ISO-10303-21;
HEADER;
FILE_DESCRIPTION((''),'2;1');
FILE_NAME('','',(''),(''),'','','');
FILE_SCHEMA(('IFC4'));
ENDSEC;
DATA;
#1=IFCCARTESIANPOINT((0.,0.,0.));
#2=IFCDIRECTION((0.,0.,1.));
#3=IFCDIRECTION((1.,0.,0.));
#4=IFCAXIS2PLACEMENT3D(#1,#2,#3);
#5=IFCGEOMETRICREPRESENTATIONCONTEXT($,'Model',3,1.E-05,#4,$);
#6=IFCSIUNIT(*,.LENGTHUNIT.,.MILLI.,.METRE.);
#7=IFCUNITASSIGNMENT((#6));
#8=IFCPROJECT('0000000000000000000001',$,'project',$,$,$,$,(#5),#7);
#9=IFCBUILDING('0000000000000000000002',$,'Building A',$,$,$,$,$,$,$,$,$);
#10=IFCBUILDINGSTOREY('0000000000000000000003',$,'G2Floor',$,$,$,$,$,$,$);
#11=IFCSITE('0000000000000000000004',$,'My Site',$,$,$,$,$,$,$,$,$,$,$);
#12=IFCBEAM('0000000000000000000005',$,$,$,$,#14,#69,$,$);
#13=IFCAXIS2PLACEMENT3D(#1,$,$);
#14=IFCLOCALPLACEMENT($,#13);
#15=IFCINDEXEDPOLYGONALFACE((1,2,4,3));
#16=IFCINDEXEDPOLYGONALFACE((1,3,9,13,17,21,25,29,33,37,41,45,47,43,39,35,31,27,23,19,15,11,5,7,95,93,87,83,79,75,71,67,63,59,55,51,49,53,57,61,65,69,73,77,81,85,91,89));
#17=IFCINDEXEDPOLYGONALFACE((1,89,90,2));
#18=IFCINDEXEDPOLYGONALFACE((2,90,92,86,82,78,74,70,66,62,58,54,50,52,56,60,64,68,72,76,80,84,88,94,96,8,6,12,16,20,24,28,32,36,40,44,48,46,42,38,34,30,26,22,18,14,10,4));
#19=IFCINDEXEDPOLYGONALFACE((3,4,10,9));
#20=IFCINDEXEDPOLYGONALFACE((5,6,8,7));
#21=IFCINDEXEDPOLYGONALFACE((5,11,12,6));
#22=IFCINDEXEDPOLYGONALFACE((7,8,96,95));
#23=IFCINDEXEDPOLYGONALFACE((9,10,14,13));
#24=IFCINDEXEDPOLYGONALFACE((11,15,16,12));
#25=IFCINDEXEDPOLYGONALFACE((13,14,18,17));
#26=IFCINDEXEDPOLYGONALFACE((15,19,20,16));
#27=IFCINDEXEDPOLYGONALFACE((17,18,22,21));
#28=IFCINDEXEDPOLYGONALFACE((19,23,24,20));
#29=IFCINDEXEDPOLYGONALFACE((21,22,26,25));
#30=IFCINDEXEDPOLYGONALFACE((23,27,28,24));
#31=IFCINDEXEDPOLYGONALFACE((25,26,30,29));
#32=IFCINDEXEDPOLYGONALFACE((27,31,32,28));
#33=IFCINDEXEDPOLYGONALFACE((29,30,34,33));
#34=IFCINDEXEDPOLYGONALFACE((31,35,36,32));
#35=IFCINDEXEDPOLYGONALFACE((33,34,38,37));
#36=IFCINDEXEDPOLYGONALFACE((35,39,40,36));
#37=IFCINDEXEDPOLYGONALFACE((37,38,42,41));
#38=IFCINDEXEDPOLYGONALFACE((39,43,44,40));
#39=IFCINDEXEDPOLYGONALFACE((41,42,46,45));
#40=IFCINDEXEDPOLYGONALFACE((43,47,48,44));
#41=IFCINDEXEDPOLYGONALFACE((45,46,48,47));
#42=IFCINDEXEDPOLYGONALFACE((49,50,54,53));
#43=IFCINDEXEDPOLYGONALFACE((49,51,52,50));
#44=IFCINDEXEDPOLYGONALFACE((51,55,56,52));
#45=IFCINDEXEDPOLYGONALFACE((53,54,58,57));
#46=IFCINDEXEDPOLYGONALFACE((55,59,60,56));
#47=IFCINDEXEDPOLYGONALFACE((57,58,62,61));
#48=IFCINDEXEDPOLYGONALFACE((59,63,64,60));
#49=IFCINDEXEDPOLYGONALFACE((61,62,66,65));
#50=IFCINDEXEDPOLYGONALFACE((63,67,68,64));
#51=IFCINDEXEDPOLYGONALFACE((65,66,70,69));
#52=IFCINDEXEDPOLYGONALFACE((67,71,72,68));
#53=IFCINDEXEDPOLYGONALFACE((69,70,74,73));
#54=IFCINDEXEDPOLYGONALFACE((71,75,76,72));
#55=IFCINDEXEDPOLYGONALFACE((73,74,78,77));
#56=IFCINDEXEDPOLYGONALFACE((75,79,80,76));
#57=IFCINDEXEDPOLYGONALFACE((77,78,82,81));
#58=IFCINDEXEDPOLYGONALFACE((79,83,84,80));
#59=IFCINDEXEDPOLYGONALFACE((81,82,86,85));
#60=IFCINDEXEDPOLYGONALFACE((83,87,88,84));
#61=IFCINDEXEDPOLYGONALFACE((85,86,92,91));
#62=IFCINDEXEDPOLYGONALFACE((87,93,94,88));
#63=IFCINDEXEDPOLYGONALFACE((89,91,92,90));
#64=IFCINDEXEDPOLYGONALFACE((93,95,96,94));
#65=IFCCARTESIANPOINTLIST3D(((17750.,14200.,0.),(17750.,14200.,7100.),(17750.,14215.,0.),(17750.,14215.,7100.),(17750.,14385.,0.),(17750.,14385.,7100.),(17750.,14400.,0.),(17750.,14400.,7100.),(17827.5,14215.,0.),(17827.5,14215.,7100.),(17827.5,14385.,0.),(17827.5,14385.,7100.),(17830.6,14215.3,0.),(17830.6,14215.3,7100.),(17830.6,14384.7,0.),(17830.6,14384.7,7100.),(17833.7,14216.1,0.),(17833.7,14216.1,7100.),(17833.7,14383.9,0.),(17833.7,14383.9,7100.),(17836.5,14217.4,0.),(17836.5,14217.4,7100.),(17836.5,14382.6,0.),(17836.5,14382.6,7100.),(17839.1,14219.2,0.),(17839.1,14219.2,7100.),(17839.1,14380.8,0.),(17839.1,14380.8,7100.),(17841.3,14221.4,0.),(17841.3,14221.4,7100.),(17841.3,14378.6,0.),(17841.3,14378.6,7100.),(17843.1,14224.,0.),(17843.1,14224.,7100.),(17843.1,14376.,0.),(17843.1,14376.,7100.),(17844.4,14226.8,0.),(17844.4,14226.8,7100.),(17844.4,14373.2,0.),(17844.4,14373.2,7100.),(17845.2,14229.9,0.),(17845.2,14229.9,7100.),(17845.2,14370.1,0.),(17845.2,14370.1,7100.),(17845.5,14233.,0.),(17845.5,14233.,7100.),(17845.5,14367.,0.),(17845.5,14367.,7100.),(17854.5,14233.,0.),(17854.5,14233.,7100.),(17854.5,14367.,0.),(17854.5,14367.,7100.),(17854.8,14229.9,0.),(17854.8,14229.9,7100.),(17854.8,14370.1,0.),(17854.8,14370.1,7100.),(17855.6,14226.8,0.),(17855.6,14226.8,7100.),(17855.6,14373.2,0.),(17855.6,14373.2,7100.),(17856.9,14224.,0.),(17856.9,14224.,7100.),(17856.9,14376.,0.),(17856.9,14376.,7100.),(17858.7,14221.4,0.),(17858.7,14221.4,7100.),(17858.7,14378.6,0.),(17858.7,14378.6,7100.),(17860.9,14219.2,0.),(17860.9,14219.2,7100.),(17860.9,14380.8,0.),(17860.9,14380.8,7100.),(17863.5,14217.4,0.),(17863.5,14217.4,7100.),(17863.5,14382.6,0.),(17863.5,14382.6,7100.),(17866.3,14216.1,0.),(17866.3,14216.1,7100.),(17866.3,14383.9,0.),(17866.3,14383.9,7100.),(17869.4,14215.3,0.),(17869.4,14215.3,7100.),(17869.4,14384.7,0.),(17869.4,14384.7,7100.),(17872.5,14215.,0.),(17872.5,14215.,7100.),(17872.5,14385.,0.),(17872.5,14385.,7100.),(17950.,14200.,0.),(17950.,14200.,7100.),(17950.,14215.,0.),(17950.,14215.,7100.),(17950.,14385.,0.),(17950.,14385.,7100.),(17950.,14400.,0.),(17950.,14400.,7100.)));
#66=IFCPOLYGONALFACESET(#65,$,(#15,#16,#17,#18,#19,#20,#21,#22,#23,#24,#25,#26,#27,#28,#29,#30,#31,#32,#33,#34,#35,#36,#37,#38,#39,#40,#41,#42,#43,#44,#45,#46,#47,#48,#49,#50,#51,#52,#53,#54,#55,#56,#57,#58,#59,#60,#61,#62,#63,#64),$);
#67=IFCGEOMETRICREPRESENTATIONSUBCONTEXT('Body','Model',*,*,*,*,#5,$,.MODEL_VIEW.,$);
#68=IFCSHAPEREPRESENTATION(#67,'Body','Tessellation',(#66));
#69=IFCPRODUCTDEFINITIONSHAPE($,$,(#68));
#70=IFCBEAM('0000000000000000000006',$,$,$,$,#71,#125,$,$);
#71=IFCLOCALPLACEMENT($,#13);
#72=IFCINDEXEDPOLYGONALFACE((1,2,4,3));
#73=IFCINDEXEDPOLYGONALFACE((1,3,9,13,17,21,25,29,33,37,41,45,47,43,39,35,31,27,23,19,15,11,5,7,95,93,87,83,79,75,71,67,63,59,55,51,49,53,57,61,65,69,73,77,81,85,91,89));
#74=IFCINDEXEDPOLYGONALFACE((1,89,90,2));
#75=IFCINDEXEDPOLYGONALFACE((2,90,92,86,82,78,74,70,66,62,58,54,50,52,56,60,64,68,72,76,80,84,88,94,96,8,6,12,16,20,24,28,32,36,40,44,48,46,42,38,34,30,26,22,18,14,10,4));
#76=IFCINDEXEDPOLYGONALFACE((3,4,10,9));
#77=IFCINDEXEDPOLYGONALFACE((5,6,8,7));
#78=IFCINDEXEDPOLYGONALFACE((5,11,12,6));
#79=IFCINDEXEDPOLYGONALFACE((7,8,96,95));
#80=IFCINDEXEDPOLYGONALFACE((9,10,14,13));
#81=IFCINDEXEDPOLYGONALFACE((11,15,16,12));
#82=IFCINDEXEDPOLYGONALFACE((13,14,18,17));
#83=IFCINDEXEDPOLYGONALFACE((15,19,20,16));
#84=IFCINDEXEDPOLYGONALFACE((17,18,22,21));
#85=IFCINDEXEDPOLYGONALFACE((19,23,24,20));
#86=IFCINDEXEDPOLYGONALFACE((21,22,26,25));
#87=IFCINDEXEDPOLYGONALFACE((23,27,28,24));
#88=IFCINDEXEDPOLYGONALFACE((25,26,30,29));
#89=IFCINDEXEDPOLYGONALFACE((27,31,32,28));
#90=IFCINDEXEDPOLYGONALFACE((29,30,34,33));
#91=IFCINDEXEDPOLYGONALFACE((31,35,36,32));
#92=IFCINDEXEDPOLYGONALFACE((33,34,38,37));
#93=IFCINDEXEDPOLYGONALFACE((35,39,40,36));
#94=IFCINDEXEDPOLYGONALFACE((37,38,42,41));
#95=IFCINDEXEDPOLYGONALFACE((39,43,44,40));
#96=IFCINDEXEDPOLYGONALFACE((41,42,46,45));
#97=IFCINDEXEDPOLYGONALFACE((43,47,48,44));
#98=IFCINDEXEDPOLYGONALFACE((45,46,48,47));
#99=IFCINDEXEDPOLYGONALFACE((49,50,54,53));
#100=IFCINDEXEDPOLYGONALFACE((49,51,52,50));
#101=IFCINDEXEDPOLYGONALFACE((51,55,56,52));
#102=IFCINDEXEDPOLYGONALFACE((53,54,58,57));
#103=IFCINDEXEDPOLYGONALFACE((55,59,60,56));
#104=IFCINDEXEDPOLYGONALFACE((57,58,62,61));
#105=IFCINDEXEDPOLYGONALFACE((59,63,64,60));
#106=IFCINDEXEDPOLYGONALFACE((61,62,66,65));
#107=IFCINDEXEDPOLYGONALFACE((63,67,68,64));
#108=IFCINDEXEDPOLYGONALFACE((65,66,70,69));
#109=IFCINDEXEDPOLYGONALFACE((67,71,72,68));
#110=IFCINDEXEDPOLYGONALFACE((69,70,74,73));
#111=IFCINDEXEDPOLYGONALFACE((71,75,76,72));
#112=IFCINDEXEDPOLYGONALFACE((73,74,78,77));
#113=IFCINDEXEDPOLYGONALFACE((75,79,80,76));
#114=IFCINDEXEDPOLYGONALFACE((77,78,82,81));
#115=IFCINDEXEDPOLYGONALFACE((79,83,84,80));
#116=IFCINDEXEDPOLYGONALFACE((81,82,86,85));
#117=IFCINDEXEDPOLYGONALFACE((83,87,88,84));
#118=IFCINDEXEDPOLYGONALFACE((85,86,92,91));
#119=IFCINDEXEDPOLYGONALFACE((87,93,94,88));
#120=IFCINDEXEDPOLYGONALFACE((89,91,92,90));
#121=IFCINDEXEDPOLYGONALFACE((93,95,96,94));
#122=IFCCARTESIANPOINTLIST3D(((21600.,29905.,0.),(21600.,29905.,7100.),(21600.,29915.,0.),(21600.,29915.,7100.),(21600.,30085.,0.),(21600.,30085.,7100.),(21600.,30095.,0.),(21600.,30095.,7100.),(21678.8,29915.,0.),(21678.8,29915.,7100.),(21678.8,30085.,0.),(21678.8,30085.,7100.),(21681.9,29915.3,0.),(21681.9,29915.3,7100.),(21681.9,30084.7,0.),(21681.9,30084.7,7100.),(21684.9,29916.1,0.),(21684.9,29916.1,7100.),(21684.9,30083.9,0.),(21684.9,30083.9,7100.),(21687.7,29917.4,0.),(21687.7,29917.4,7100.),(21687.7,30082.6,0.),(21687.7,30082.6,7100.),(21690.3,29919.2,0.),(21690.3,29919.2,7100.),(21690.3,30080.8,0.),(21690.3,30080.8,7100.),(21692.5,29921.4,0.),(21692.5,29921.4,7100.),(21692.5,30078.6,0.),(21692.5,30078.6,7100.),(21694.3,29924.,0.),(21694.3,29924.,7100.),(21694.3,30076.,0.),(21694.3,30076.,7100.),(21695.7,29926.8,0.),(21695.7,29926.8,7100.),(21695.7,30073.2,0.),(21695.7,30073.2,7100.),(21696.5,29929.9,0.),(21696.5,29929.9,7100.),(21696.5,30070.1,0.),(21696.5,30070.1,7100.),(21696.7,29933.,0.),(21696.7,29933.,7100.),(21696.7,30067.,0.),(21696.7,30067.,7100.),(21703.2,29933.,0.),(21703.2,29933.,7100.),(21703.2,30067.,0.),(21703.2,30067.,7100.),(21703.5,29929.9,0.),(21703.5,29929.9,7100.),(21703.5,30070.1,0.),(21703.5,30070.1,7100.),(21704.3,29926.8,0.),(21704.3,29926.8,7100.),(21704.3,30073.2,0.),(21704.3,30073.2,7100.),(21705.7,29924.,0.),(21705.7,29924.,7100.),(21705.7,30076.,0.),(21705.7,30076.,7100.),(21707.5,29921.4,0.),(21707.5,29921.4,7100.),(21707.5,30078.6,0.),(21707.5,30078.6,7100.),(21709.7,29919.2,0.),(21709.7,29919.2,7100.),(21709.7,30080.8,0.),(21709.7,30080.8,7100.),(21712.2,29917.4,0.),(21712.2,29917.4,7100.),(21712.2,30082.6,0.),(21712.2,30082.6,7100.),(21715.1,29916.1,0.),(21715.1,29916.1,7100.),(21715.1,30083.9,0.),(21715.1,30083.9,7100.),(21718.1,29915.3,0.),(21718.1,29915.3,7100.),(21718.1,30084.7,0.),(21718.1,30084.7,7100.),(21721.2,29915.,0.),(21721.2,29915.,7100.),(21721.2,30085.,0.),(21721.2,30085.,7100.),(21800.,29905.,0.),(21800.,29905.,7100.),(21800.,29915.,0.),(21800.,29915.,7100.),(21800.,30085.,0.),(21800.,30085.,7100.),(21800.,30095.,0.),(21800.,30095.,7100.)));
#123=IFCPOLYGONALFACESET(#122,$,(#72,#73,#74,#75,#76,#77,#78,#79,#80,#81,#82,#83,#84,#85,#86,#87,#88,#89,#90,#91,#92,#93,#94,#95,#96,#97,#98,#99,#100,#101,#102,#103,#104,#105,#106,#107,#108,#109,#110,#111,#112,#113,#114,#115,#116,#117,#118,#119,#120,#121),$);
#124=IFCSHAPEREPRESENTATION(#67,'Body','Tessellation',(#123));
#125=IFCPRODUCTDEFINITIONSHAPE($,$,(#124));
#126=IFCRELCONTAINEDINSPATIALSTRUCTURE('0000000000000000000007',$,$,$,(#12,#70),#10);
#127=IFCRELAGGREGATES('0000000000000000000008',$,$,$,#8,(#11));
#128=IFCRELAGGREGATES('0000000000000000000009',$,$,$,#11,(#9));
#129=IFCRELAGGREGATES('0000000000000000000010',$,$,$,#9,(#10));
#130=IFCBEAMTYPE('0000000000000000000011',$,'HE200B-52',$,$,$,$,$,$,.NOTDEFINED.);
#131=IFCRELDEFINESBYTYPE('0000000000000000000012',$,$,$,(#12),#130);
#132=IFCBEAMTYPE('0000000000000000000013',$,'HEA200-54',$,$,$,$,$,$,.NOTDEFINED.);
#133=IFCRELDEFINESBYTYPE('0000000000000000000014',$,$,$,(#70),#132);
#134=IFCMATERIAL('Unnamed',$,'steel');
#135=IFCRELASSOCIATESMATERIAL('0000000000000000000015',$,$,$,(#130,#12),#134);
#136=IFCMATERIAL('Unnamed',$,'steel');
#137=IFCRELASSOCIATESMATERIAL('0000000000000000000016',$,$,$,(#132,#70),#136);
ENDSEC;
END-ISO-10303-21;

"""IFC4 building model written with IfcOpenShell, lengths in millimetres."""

from ifc_helpers import new_model, si_unit, frame, origin_with_axes, place, context, subcontext, project, spatial, polyline, outline, extrude, material, material_profile, profile_set, profile_usage, type_object, element, save


model = new_model("IFC4")

# Units and contexts
model_context = context("Model", 3, precision=1e-05, world=origin_with_axes())
body_context = subcontext(model_context, "Body", "Model", "MODEL_VIEW")
ifc_project = project(units=[si_unit("LENGTHUNIT", "METRE", prefix="MILLI")], contexts=[model_context])

# Site, building, storey
site = spatial("IfcSite", under=ifc_project, Name="My Site")
building = spatial("IfcBuilding", under=site, Name="Building A")
storey = spatial("IfcBuildingStorey", under=building, Name="G2Floor")

# Beams
ifc_material_1 = material(Name="Unnamed", Category="steel")
ifc_material_profile_1 = material_profile(ifc_material_1, outline(polyline([(100.0, -100.0), (100.0, -85.0), (100.0, -85.0), (22.5, -85.0), (22.5, -85.0), (19.4, -84.7), (19.4, -84.7), (16.3, -83.9), (16.3, -83.9), (13.5, -82.6), (13.5, -82.6), (10.9, -80.8), (10.9, -80.8), (8.7, -78.6), (8.7, -78.6), (6.9, -76.0), (6.9, -76.0), (5.6, -73.2), (5.6, -73.2), (4.8, -70.1), (4.8, -70.1), (4.5, -67.0), (4.5, -67.0), (4.5, 67.0), (4.5, 67.0), (4.8, 70.1), (4.8, 70.1), (5.6, 73.2), (5.6, 73.2), (6.9, 76.0), (6.9, 76.0), (8.7, 78.6), (8.7, 78.6), (10.9, 80.8), (10.9, 80.8), (13.5, 82.6), (13.5, 82.6), (16.3, 83.9), (16.3, 83.9), (19.4, 84.7), (19.4, 84.7), (22.5, 85.0), (22.5, 85.0), (100.0, 85.0), (100.0, 85.0), (100.0, 100.0), (100.0, 100.0), (-100.0, 100.0), (-100.0, 100.0), (-100.0, 85.0), (-100.0, 85.0), (-22.5, 85.0), (-22.5, 85.0), (-19.4, 84.7), (-19.4, 84.7), (-16.3, 83.9), (-16.3, 83.9), (-13.5, 82.6), (-13.5, 82.6), (-10.9, 80.8), (-10.9, 80.8), (-8.7, 78.6), (-8.7, 78.6), (-6.9, 76.0), (-6.9, 76.0), (-5.6, 73.2), (-5.6, 73.2), (-4.8, 70.1), (-4.8, 70.1), (-4.5, 67.0), (-4.5, 67.0), (-4.5, -67.0), (-4.5, -67.0), (-4.8, -70.1), (-4.8, -70.1), (-5.6, -73.2), (-5.6, -73.2), (-6.9, -76.0), (-6.9, -76.0), (-8.7, -78.6), (-8.7, -78.6), (-10.9, -80.8), (-10.9, -80.8), (-13.5, -82.6), (-13.5, -82.6), (-16.3, -83.9), (-16.3, -83.9), (-19.4, -84.7), (-19.4, -84.7), (-22.5, -85.0), (-22.5, -85.0), (-100.0, -85.0), (-100.0, -85.0), (-100.0, -100.0), (-100.0, -100.0), (100.0, -100.0)])))
ifc_profile_set_1 = profile_set([ifc_material_profile_1], Name="HE200B-52")
ifc_profile_usage_1 = profile_usage(ifc_profile_set_1)
beam_type_1 = type_object("IfcBeamType", Name="HE200B-52", PredefinedType="NOTDEFINED", material=ifc_profile_set_1)
beam_1_placement = place(None, frame((17850.0, 14300.0, 0.0), z_axis=(0.0, 0.0, 1.0), x_axis=(1.0, 0.0, 0.0)))
element("IfcBeam", 1, at=beam_1_placement, inside=storey, type_object=beam_type_1, material=ifc_profile_usage_1, context=body_context, shape_type="SweptSolid", body=[
    extrude(outline(polyline([(100.0, -100.0), (100.0, -85.0), (100.0, -85.0), (22.5, -85.0), (22.5, -85.0), (19.4, -84.7), (19.4, -84.7), (16.3, -83.9), (16.3, -83.9), (13.5, -82.6), (13.5, -82.6), (10.9, -80.8), (10.9, -80.8), (8.7, -78.6), (8.7, -78.6), (6.9, -76.0), (6.9, -76.0), (5.6, -73.2), (5.6, -73.2), (4.8, -70.1), (4.8, -70.1), (4.5, -67.0), (4.5, -67.0), (4.5, 67.0), (4.5, 67.0), (4.8, 70.1), (4.8, 70.1), (5.6, 73.2), (5.6, 73.2), (6.9, 76.0), (6.9, 76.0), (8.7, 78.6), (8.7, 78.6), (10.9, 80.8), (10.9, 80.8), (13.5, 82.6), (13.5, 82.6), (16.3, 83.9), (16.3, 83.9), (19.4, 84.7), (19.4, 84.7), (22.5, 85.0), (22.5, 85.0), (100.0, 85.0), (100.0, 85.0), (100.0, 100.0), (100.0, 100.0), (-100.0, 100.0), (-100.0, 100.0), (-100.0, 85.0), (-100.0, 85.0), (-22.5, 85.0), (-22.5, 85.0), (-19.4, 84.7), (-19.4, 84.7), (-16.3, 83.9), (-16.3, 83.9), (-13.5, 82.6), (-13.5, 82.6), (-10.9, 80.8), (-10.9, 80.8), (-8.7, 78.6), (-8.7, 78.6), (-6.9, 76.0), (-6.9, 76.0), (-5.6, 73.2), (-5.6, 73.2), (-4.8, 70.1), (-4.8, 70.1), (-4.5, 67.0), (-4.5, 67.0), (-4.5, -67.0), (-4.5, -67.0), (-4.8, -70.1), (-4.8, -70.1), (-5.6, -73.2), (-5.6, -73.2), (-6.9, -76.0), (-6.9, -76.0), (-8.7, -78.6), (-8.7, -78.6), (-10.9, -80.8), (-10.9, -80.8), (-13.5, -82.6), (-13.5, -82.6), (-16.3, -83.9), (-16.3, -83.9), (-19.4, -84.7), (-19.4, -84.7), (-22.5, -85.0), (-22.5, -85.0), (-100.0, -85.0), (-100.0, -85.0), (-100.0, -100.0), (-100.0, -100.0), (100.0, -100.0)])), origin_with_axes(), (0.0, 0.0, 1.0), 7100.0),
])
ifc_material_2 = material(Name="Unnamed", Category="steel")
ifc_material_profile_2 = material_profile(ifc_material_2, outline(polyline([(100.0, -95.0), (100.0, -85.0), (100.0, -85.0), (21.2, -85.0), (21.2, -85.0), (18.1, -84.7), (18.1, -84.7), (15.1, -83.9), (15.1, -83.9), (12.2, -82.6), (12.2, -82.6), (9.7, -80.8), (9.7, -80.8), (7.5, -78.6), (7.5, -78.6), (5.7, -76.0), (5.7, -76.0), (4.3, -73.2), (4.3, -73.2), (3.5, -70.1), (3.5, -70.1), (3.2, -67.0), (3.2, -67.0), (3.2, 67.0), (3.2, 67.0), (3.5, 70.1), (3.5, 70.1), (4.3, 73.2), (4.3, 73.2), (5.7, 76.0), (5.7, 76.0), (7.5, 78.6), (7.5, 78.6), (9.7, 80.8), (9.7, 80.8), (12.2, 82.6), (12.2, 82.6), (15.1, 83.9), (15.1, 83.9), (18.1, 84.7), (18.1, 84.7), (21.2, 85.0), (21.2, 85.0), (100.0, 85.0), (100.0, 85.0), (100.0, 95.0), (100.0, 95.0), (-100.0, 95.0), (-100.0, 95.0), (-100.0, 85.0), (-100.0, 85.0), (-21.2, 85.0), (-21.2, 85.0), (-18.1, 84.7), (-18.1, 84.7), (-15.1, 83.9), (-15.1, 83.9), (-12.2, 82.6), (-12.2, 82.6), (-9.7, 80.8), (-9.7, 80.8), (-7.5, 78.6), (-7.5, 78.6), (-5.7, 76.0), (-5.7, 76.0), (-4.3, 73.2), (-4.3, 73.2), (-3.5, 70.1), (-3.5, 70.1), (-3.2, 67.0), (-3.2, 67.0), (-3.2, -67.0), (-3.2, -67.0), (-3.5, -70.1), (-3.5, -70.1), (-4.3, -73.2), (-4.3, -73.2), (-5.7, -76.0), (-5.7, -76.0), (-7.5, -78.6), (-7.5, -78.6), (-9.7, -80.8), (-9.7, -80.8), (-12.2, -82.6), (-12.2, -82.6), (-15.1, -83.9), (-15.1, -83.9), (-18.1, -84.7), (-18.1, -84.7), (-21.2, -85.0), (-21.2, -85.0), (-100.0, -85.0), (-100.0, -85.0), (-100.0, -95.0), (-100.0, -95.0), (100.0, -95.0)])))
ifc_profile_set_2 = profile_set([ifc_material_profile_2], Name="HEA200-54")
ifc_profile_usage_2 = profile_usage(ifc_profile_set_2)
beam_type_2 = type_object("IfcBeamType", Name="HEA200-54", PredefinedType="NOTDEFINED", material=ifc_profile_set_2)
beam_2_placement = place(None, frame((21700.0, 30000.0, 0.0), z_axis=(0.0, 0.0, 1.0), x_axis=(1.0, 0.0, 0.0)))
element("IfcBeam", 2, at=beam_2_placement, inside=storey, type_object=beam_type_2, material=ifc_profile_usage_2, context=body_context, shape_type="SweptSolid", body=[
    extrude(outline(polyline([(100.0, -95.0), (100.0, -85.0), (100.0, -85.0), (21.2, -85.0), (21.2, -85.0), (18.1, -84.7), (18.1, -84.7), (15.1, -83.9), (15.1, -83.9), (12.2, -82.6), (12.2, -82.6), (9.7, -80.8), (9.7, -80.8), (7.5, -78.6), (7.5, -78.6), (5.7, -76.0), (5.7, -76.0), (4.3, -73.2), (4.3, -73.2), (3.5, -70.1), (3.5, -70.1), (3.2, -67.0), (3.2, -67.0), (3.2, 67.0), (3.2, 67.0), (3.5, 70.1), (3.5, 70.1), (4.3, 73.2), (4.3, 73.2), (5.7, 76.0), (5.7, 76.0), (7.5, 78.6), (7.5, 78.6), (9.7, 80.8), (9.7, 80.8), (12.2, 82.6), (12.2, 82.6), (15.1, 83.9), (15.1, 83.9), (18.1, 84.7), (18.1, 84.7), (21.2, 85.0), (21.2, 85.0), (100.0, 85.0), (100.0, 85.0), (100.0, 95.0), (100.0, 95.0), (-100.0, 95.0), (-100.0, 95.0), (-100.0, 85.0), (-100.0, 85.0), (-21.2, 85.0), (-21.2, 85.0), (-18.1, 84.7), (-18.1, 84.7), (-15.1, 83.9), (-15.1, 83.9), (-12.2, 82.6), (-12.2, 82.6), (-9.7, 80.8), (-9.7, 80.8), (-7.5, 78.6), (-7.5, 78.6), (-5.7, 76.0), (-5.7, 76.0), (-4.3, 73.2), (-4.3, 73.2), (-3.5, 70.1), (-3.5, 70.1), (-3.2, 67.0), (-3.2, 67.0), (-3.2, -67.0), (-3.2, -67.0), (-3.5, -70.1), (-3.5, -70.1), (-4.3, -73.2), (-4.3, -73.2), (-5.7, -76.0), (-5.7, -76.0), (-7.5, -78.6), (-7.5, -78.6), (-9.7, -80.8), (-9.7, -80.8), (-12.2, -82.6), (-12.2, -82.6), (-15.1, -83.9), (-15.1, -83.9), (-18.1, -84.7), (-18.1, -84.7), (-21.2, -85.0), (-21.2, -85.0), (-100.0, -85.0), (-100.0, -85.0), (-100.0, -95.0), (-100.0, -95.0), (100.0, -95.0)])), origin_with_axes(), (0.0, 0.0, 1.0), 7100.0),
])

save(model, "model.ifc")
